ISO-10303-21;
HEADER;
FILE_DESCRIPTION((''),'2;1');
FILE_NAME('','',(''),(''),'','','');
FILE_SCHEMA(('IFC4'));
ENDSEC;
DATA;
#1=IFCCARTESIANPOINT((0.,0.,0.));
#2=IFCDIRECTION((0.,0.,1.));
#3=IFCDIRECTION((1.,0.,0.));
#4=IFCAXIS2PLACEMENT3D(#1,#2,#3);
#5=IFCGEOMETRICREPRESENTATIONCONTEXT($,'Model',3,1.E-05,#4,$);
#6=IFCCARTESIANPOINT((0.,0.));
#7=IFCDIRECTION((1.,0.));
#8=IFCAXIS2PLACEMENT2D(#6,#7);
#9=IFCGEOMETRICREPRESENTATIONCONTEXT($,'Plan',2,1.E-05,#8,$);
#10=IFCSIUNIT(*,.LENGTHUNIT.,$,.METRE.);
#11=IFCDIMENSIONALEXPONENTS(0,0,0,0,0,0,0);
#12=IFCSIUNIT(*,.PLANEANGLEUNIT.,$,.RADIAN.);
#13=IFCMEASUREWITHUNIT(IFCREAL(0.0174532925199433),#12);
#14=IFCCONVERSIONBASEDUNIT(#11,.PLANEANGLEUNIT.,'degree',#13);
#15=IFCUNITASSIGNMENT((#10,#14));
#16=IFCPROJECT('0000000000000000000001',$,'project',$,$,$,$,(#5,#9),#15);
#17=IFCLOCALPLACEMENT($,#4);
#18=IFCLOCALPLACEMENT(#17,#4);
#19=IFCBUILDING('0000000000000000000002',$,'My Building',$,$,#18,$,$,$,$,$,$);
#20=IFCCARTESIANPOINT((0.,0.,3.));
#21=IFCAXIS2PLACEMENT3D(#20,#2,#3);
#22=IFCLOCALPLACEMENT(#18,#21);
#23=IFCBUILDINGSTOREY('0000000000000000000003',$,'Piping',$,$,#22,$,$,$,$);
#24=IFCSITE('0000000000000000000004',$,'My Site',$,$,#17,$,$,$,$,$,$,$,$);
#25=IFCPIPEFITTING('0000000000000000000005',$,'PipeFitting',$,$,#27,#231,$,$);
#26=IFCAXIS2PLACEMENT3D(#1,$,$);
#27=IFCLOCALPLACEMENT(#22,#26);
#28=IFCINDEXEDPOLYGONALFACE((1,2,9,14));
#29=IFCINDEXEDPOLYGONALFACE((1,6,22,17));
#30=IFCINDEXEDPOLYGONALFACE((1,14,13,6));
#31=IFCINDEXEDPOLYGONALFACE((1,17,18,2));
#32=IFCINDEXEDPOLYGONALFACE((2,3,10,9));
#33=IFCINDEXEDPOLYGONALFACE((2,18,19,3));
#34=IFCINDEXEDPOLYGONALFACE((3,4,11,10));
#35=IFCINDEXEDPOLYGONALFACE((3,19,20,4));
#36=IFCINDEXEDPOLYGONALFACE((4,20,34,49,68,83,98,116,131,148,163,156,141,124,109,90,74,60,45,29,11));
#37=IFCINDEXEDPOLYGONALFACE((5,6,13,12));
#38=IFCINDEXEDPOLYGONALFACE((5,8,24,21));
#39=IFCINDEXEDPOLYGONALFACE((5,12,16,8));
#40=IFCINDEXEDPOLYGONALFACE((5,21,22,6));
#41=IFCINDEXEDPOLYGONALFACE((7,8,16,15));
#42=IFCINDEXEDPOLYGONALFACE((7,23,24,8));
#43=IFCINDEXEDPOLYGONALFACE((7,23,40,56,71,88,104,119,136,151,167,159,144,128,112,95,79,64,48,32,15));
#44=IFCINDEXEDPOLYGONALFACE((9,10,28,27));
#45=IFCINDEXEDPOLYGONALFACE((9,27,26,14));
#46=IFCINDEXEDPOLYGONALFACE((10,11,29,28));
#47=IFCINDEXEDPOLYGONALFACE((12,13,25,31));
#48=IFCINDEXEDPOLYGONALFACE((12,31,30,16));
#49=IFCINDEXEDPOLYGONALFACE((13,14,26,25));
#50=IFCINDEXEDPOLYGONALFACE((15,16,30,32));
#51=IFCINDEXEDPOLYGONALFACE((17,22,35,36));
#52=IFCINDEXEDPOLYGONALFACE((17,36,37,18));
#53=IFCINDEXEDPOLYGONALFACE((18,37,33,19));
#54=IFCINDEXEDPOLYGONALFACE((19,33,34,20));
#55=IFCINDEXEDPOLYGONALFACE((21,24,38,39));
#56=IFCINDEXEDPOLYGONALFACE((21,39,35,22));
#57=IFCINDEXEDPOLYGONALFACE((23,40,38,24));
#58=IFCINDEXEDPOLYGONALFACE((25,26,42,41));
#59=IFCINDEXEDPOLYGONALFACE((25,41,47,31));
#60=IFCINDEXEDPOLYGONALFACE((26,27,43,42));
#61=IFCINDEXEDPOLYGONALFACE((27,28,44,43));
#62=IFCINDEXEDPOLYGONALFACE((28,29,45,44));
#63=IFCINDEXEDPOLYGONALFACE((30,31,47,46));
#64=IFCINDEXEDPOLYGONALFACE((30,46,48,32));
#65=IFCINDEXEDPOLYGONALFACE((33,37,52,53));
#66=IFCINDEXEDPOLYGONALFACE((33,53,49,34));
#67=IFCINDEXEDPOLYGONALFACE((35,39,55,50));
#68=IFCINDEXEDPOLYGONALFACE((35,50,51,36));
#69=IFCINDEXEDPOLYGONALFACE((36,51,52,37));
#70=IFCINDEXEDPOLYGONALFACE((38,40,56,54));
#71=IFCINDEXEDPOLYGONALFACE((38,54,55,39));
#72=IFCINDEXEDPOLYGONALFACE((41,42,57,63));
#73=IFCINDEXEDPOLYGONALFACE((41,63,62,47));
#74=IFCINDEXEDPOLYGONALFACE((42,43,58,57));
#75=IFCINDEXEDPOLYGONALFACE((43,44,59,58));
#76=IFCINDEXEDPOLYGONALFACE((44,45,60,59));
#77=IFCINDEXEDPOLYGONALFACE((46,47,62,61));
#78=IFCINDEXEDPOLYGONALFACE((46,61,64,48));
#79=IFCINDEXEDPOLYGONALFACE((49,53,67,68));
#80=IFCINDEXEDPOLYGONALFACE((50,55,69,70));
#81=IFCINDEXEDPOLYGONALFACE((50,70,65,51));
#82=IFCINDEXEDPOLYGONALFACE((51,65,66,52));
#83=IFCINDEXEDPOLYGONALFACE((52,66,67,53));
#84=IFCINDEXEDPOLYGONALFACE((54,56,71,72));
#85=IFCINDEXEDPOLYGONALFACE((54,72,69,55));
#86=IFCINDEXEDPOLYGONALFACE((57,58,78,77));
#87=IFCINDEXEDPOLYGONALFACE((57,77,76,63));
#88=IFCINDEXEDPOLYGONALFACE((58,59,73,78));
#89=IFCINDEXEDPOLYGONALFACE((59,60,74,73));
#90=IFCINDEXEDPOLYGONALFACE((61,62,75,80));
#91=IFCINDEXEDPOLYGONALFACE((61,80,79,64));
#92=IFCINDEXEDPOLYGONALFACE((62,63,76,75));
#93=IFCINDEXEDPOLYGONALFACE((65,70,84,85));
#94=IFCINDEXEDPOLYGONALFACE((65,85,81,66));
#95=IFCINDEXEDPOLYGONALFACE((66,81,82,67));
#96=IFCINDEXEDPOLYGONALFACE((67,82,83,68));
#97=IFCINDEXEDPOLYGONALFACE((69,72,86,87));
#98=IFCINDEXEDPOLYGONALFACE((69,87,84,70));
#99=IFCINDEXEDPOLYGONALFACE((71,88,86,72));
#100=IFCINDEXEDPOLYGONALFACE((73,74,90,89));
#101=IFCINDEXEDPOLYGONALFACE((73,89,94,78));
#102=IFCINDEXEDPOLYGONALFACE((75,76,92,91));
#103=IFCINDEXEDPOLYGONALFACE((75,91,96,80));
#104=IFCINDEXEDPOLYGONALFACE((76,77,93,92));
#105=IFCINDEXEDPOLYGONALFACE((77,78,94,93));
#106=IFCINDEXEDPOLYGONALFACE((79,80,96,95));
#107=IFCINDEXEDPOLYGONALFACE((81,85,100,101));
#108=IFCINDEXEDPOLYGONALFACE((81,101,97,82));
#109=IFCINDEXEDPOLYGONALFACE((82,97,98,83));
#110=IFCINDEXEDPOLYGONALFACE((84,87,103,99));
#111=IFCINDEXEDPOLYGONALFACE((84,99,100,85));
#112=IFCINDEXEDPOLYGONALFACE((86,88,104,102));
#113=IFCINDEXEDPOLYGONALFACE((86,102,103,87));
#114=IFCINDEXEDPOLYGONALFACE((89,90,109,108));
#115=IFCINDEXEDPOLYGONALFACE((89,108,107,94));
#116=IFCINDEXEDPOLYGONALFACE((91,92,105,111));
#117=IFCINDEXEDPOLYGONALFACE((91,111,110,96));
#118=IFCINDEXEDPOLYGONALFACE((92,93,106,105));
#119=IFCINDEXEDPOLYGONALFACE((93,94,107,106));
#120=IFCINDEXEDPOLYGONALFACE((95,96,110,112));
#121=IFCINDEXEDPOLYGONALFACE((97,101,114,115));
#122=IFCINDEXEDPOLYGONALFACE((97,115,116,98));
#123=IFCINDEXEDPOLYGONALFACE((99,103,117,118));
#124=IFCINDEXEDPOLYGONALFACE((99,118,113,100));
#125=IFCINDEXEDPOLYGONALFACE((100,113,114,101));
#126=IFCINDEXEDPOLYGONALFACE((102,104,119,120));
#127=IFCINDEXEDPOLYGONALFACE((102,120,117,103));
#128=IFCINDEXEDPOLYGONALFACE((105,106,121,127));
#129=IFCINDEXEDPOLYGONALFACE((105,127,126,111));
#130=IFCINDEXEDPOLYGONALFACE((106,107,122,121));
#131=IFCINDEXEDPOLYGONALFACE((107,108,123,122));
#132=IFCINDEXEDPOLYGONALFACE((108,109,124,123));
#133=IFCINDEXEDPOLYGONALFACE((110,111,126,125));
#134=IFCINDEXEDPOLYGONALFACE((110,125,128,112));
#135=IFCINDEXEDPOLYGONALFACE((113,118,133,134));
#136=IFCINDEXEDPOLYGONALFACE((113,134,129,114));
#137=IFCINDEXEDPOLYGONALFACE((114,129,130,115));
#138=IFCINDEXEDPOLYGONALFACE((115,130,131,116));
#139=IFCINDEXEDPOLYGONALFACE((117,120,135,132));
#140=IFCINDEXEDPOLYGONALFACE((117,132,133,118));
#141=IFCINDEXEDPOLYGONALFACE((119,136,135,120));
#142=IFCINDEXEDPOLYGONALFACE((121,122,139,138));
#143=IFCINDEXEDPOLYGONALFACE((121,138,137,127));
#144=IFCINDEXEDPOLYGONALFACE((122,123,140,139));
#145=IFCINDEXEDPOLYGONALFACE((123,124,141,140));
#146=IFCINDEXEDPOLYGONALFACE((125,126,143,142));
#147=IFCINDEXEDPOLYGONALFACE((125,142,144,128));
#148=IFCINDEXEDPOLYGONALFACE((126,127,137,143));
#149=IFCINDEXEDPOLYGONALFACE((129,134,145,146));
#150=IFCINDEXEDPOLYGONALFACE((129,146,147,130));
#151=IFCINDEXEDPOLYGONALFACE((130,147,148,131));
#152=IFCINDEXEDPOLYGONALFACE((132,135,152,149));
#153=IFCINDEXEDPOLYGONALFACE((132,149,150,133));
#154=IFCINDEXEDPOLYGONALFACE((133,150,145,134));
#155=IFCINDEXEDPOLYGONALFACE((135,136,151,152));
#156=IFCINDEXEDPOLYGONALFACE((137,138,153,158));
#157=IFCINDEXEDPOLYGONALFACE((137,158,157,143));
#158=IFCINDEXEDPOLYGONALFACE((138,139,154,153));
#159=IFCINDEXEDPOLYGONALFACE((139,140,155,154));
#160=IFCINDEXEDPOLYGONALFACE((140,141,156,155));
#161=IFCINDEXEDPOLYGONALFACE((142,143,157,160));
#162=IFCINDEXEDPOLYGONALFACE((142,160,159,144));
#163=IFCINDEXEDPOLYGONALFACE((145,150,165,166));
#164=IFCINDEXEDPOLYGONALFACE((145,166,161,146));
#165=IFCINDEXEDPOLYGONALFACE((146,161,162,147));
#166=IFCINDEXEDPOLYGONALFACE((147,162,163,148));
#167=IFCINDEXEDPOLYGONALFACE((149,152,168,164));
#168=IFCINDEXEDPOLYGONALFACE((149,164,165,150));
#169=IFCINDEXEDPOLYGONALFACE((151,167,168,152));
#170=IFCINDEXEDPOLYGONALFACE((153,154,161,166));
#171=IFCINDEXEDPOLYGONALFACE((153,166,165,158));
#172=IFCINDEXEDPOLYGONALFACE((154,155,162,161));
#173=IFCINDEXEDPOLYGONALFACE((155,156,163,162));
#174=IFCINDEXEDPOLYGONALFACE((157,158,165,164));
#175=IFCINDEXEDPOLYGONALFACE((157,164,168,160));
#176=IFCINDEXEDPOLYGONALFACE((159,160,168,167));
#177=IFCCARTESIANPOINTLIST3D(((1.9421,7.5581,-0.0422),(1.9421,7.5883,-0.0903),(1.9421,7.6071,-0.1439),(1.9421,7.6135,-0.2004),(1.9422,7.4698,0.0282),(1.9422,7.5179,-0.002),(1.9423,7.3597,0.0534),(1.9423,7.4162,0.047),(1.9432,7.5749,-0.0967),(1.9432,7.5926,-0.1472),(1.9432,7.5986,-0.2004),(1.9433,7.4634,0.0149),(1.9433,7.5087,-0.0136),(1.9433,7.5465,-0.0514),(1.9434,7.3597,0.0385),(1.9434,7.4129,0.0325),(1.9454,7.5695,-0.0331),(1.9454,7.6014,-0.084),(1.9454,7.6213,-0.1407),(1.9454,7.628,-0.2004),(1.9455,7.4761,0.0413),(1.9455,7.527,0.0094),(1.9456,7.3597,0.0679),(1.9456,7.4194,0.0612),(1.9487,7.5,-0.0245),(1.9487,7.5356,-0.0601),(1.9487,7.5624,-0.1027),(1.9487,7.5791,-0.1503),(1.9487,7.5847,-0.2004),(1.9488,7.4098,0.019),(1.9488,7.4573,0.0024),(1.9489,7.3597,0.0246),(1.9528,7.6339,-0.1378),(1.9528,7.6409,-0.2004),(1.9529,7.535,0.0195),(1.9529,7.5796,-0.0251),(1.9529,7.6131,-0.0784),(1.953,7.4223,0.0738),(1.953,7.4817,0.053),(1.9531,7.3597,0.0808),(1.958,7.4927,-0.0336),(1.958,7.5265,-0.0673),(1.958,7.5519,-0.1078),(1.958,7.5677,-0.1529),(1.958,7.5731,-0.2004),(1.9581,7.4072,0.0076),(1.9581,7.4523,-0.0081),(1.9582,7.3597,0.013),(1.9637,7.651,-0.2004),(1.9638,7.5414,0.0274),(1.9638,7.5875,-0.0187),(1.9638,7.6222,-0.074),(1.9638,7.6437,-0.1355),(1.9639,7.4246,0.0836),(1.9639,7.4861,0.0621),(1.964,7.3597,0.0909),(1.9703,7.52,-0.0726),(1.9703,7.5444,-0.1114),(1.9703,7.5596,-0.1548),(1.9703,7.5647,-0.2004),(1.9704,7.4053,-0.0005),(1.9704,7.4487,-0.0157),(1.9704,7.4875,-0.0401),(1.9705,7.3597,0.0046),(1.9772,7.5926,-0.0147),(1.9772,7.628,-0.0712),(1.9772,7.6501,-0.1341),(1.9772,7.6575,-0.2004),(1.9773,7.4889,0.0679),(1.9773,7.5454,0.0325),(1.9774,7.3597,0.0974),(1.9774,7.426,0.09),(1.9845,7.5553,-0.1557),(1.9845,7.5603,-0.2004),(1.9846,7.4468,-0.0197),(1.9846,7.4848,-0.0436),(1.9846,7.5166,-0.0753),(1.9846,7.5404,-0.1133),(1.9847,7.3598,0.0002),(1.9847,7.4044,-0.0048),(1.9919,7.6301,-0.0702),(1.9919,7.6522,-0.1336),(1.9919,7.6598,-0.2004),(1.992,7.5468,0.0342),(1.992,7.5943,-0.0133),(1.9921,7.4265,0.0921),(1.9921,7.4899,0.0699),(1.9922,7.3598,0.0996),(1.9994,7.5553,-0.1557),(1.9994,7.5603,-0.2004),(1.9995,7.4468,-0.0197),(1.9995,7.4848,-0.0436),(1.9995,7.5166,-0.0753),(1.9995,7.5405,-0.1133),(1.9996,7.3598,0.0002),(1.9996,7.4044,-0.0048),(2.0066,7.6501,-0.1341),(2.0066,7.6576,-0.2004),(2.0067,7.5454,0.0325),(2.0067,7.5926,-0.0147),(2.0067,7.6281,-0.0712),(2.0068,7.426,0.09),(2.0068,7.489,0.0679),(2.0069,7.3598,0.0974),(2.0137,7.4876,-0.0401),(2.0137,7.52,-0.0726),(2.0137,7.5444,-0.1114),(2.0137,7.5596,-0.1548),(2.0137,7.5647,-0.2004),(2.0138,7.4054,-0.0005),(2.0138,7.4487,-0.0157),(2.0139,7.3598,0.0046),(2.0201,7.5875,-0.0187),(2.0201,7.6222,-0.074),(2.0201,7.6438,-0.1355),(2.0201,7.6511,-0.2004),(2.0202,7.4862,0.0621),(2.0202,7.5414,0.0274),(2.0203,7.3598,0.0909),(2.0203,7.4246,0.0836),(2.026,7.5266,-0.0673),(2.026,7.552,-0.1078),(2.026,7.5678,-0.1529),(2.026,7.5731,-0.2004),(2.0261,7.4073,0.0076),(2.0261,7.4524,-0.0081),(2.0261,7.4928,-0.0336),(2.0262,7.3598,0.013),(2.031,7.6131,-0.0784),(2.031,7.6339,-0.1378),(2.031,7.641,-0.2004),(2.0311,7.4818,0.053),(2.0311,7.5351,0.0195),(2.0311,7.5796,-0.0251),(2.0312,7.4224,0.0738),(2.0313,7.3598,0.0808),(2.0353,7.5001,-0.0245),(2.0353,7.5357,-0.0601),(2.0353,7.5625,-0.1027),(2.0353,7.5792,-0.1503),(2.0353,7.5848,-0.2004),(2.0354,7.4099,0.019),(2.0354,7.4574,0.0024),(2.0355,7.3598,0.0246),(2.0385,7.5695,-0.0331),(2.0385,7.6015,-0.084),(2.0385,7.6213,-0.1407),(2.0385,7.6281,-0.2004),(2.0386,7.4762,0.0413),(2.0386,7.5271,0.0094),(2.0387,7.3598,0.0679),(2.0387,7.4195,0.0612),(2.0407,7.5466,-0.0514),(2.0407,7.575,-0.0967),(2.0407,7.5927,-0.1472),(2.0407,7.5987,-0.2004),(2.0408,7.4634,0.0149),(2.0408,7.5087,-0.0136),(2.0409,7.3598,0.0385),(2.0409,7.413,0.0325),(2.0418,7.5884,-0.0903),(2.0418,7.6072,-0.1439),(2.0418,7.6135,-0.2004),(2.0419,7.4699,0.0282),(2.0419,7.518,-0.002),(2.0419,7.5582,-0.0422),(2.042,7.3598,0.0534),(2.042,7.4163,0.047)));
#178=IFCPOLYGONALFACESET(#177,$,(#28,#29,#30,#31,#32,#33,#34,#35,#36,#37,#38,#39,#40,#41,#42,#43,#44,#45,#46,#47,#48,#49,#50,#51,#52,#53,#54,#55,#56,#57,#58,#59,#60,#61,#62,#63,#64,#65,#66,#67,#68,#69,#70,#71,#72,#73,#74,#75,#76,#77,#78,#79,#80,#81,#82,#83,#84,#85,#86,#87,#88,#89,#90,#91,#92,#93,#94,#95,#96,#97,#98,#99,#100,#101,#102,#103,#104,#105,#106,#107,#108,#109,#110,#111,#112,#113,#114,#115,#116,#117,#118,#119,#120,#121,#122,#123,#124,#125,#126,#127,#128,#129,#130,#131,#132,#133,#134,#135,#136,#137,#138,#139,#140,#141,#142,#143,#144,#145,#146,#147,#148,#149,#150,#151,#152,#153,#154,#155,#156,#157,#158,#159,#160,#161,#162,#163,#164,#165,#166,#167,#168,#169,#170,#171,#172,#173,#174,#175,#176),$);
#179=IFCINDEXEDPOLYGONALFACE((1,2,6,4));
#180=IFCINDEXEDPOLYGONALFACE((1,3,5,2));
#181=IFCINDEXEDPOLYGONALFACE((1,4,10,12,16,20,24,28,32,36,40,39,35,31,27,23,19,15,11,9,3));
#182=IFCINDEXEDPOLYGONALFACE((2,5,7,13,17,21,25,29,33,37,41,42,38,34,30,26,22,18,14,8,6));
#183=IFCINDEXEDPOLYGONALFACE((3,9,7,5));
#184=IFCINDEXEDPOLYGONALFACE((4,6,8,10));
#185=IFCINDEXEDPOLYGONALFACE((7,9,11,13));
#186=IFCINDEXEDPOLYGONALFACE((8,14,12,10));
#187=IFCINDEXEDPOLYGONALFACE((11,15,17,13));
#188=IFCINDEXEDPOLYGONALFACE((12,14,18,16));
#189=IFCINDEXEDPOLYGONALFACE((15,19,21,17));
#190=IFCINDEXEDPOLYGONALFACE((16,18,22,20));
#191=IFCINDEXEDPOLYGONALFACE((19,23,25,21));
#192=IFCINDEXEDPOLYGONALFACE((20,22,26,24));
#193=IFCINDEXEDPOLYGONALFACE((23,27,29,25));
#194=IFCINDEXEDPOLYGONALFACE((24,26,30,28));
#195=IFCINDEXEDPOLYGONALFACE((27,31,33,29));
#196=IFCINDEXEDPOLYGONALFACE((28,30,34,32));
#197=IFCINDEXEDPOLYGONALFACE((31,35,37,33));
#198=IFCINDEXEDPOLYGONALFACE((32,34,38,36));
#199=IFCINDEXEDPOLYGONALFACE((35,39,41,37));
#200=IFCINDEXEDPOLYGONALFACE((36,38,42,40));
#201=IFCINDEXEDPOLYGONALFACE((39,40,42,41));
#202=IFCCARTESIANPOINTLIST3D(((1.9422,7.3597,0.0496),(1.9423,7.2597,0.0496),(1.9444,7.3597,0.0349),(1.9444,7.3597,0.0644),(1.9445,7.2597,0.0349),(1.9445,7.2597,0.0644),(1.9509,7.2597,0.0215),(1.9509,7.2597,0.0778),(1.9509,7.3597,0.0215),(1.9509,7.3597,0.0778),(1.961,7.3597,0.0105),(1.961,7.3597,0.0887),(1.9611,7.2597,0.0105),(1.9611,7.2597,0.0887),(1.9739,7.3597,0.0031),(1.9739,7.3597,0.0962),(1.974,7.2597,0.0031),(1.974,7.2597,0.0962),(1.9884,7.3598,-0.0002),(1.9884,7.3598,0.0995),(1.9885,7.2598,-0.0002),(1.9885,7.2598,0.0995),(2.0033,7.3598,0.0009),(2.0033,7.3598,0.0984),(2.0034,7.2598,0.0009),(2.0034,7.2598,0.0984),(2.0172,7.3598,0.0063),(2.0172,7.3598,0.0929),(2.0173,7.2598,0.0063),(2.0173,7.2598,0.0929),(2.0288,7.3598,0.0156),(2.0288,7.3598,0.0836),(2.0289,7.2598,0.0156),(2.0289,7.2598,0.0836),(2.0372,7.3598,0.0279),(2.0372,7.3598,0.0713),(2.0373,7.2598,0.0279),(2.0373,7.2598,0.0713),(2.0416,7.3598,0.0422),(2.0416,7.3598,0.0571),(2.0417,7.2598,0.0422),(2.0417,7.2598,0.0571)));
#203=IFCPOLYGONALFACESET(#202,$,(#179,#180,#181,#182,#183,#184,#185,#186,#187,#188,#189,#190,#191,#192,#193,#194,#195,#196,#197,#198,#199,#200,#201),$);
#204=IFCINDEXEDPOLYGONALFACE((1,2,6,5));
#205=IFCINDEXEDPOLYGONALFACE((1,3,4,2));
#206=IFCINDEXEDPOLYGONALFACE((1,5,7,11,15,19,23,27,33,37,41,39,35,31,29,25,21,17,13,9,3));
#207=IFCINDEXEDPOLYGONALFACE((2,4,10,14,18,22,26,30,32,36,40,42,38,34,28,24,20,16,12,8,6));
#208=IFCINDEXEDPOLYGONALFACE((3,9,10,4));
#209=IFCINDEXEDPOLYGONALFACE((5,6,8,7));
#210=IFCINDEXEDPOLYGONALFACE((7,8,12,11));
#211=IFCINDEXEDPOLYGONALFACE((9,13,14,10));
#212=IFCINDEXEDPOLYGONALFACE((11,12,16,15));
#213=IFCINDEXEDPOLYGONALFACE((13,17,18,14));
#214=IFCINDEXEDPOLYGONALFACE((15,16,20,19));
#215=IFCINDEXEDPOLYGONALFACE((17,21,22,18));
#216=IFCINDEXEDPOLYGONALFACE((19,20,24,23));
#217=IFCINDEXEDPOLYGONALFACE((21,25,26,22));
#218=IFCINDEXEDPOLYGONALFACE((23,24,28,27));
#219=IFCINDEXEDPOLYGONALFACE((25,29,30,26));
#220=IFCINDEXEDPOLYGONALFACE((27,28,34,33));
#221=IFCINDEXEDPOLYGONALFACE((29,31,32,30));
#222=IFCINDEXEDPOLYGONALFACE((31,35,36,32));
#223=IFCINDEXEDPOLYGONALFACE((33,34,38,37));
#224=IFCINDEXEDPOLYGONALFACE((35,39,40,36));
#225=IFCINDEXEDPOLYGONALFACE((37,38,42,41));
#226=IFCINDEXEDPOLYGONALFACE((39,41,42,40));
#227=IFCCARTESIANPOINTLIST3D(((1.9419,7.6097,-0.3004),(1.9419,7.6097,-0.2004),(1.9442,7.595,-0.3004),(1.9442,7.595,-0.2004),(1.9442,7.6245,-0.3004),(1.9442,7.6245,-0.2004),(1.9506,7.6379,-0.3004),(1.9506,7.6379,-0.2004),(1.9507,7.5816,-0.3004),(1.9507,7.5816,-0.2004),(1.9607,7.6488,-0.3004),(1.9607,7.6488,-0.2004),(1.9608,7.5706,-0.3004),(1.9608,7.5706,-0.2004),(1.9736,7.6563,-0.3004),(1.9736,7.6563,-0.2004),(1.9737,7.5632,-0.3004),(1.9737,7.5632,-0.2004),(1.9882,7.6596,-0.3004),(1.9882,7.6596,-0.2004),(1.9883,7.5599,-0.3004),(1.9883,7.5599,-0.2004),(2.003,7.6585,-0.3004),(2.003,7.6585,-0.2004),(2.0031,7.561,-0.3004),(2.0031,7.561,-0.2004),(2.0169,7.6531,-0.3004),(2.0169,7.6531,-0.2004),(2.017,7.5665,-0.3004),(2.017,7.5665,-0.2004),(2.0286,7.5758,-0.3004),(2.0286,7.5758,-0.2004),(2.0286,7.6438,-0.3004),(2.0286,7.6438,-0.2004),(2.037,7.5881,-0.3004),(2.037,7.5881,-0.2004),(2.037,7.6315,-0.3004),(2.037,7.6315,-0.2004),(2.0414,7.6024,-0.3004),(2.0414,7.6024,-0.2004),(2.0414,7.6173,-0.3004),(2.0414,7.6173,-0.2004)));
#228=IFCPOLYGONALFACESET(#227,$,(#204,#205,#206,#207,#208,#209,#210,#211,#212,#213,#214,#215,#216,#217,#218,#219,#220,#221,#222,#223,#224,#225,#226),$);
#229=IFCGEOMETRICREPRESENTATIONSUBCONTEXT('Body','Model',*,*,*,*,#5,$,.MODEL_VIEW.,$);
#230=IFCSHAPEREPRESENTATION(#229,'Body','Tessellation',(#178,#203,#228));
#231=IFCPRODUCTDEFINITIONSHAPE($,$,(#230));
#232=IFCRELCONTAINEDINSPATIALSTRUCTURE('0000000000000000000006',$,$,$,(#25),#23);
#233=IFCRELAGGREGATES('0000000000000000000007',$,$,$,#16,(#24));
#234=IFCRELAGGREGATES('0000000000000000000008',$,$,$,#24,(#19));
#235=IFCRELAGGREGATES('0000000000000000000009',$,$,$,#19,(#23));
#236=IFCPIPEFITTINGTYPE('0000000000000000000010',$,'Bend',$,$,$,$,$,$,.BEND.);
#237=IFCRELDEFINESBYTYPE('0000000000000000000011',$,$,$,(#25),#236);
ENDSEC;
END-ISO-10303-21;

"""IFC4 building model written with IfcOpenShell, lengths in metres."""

from ifc_helpers import new_model, entity, si_unit, converted_unit, frame, origin_with_axes, origin_2d_with_axis, place, context, subcontext, project, spatial, circle, extrude, source, transform, mapped, type_object, type_shapes, element, save


model = new_model("IFC4")

# Units and contexts
model_context = context("Model", 3, precision=1e-05, world=origin_with_axes())
plan_context = context("Plan", 2, precision=1e-05, world=origin_2d_with_axis())
body_context = subcontext(model_context, "Body", "Model", "MODEL_VIEW")
ifc_project = project(units=[si_unit("LENGTHUNIT", "METRE"), converted_unit("PLANEANGLEUNIT", "degree", entity("IfcReal", 0.0174532925199433), si_unit("PLANEANGLEUNIT", "RADIAN"), dimensions=[0, 0, 0, 0, 0, 0, 0])], contexts=[model_context, plan_context])

# Site, building, storey
site_placement = place(None, origin_with_axes())
site = spatial("IfcSite", under=ifc_project, at=site_placement, Name="My Site")
building_placement = place(site_placement, origin_with_axes())
building = spatial("IfcBuilding", under=site, at=building_placement, Name="My Building")
storey_placement = place(building_placement, frame((0.0, 0.0, 3.0), z_axis=(0.0, 0.0, 1.0), x_axis=(1.0, 0.0, 0.0)))
storey = spatial("IfcBuildingStorey", under=building, at=storey_placement, Name="Piping")

# Pipe fitting
pipe_fitting_type_1 = type_object("IfcPipeFittingType", Name="Bend", PredefinedType="BEND")
shared_shape = source(origin_with_axes(), body_context, "Body", "SolidModel", [
    entity("IfcSweptDiskSolid", entity("IfcIndexedPolyCurve", entity("IfcCartesianPointList3D", [[0.0, 0.0, 0.1], [0.0, -0.0732, 0.2768], [0.0, -0.25, 0.35]]), [entity("IfcArcIndex", [1, 2, 3])]), 0.05),
    extrude(circle(Radius=0.05), origin_with_axes(), (0.0, 0.0, 1.0), 0.1),
    extrude(circle(Radius=0.05), frame((0.0, -0.25, 0.35), z_axis=(0.0, -1.0, -0.000001), x_axis=(1.0, 0.0, 0.0)), (0.0, 0.0, 1.0), 0.1),
])
type_shapes(pipe_fitting_type_1, [shared_shape])
for number, where, z_axis, x_axis, name in (
    (1, (1.9923, 7.2598, 0.0496), (-0.000872, 1.0, 0.000001), (-1.0, -0.000872, 0.0), "PipeFitting"),
):
    element("IfcPipeFitting", number, at=place(storey_placement, frame(where, z_axis=z_axis, x_axis=x_axis)), inside=storey, type_object=pipe_fitting_type_1, Name=name, context=body_context, shape_type="MappedRepresentation", body=[
        mapped(shared_shape, transform((0.0, 0.0, 0.0), x_axis=(1.0, 0.0, 0.0), y_axis=(0.0, 1.0, 0.0), z_axis=(0.0, 0.0, 1.0), scale=1.0)),
    ])

save(model, "model.ifc")
